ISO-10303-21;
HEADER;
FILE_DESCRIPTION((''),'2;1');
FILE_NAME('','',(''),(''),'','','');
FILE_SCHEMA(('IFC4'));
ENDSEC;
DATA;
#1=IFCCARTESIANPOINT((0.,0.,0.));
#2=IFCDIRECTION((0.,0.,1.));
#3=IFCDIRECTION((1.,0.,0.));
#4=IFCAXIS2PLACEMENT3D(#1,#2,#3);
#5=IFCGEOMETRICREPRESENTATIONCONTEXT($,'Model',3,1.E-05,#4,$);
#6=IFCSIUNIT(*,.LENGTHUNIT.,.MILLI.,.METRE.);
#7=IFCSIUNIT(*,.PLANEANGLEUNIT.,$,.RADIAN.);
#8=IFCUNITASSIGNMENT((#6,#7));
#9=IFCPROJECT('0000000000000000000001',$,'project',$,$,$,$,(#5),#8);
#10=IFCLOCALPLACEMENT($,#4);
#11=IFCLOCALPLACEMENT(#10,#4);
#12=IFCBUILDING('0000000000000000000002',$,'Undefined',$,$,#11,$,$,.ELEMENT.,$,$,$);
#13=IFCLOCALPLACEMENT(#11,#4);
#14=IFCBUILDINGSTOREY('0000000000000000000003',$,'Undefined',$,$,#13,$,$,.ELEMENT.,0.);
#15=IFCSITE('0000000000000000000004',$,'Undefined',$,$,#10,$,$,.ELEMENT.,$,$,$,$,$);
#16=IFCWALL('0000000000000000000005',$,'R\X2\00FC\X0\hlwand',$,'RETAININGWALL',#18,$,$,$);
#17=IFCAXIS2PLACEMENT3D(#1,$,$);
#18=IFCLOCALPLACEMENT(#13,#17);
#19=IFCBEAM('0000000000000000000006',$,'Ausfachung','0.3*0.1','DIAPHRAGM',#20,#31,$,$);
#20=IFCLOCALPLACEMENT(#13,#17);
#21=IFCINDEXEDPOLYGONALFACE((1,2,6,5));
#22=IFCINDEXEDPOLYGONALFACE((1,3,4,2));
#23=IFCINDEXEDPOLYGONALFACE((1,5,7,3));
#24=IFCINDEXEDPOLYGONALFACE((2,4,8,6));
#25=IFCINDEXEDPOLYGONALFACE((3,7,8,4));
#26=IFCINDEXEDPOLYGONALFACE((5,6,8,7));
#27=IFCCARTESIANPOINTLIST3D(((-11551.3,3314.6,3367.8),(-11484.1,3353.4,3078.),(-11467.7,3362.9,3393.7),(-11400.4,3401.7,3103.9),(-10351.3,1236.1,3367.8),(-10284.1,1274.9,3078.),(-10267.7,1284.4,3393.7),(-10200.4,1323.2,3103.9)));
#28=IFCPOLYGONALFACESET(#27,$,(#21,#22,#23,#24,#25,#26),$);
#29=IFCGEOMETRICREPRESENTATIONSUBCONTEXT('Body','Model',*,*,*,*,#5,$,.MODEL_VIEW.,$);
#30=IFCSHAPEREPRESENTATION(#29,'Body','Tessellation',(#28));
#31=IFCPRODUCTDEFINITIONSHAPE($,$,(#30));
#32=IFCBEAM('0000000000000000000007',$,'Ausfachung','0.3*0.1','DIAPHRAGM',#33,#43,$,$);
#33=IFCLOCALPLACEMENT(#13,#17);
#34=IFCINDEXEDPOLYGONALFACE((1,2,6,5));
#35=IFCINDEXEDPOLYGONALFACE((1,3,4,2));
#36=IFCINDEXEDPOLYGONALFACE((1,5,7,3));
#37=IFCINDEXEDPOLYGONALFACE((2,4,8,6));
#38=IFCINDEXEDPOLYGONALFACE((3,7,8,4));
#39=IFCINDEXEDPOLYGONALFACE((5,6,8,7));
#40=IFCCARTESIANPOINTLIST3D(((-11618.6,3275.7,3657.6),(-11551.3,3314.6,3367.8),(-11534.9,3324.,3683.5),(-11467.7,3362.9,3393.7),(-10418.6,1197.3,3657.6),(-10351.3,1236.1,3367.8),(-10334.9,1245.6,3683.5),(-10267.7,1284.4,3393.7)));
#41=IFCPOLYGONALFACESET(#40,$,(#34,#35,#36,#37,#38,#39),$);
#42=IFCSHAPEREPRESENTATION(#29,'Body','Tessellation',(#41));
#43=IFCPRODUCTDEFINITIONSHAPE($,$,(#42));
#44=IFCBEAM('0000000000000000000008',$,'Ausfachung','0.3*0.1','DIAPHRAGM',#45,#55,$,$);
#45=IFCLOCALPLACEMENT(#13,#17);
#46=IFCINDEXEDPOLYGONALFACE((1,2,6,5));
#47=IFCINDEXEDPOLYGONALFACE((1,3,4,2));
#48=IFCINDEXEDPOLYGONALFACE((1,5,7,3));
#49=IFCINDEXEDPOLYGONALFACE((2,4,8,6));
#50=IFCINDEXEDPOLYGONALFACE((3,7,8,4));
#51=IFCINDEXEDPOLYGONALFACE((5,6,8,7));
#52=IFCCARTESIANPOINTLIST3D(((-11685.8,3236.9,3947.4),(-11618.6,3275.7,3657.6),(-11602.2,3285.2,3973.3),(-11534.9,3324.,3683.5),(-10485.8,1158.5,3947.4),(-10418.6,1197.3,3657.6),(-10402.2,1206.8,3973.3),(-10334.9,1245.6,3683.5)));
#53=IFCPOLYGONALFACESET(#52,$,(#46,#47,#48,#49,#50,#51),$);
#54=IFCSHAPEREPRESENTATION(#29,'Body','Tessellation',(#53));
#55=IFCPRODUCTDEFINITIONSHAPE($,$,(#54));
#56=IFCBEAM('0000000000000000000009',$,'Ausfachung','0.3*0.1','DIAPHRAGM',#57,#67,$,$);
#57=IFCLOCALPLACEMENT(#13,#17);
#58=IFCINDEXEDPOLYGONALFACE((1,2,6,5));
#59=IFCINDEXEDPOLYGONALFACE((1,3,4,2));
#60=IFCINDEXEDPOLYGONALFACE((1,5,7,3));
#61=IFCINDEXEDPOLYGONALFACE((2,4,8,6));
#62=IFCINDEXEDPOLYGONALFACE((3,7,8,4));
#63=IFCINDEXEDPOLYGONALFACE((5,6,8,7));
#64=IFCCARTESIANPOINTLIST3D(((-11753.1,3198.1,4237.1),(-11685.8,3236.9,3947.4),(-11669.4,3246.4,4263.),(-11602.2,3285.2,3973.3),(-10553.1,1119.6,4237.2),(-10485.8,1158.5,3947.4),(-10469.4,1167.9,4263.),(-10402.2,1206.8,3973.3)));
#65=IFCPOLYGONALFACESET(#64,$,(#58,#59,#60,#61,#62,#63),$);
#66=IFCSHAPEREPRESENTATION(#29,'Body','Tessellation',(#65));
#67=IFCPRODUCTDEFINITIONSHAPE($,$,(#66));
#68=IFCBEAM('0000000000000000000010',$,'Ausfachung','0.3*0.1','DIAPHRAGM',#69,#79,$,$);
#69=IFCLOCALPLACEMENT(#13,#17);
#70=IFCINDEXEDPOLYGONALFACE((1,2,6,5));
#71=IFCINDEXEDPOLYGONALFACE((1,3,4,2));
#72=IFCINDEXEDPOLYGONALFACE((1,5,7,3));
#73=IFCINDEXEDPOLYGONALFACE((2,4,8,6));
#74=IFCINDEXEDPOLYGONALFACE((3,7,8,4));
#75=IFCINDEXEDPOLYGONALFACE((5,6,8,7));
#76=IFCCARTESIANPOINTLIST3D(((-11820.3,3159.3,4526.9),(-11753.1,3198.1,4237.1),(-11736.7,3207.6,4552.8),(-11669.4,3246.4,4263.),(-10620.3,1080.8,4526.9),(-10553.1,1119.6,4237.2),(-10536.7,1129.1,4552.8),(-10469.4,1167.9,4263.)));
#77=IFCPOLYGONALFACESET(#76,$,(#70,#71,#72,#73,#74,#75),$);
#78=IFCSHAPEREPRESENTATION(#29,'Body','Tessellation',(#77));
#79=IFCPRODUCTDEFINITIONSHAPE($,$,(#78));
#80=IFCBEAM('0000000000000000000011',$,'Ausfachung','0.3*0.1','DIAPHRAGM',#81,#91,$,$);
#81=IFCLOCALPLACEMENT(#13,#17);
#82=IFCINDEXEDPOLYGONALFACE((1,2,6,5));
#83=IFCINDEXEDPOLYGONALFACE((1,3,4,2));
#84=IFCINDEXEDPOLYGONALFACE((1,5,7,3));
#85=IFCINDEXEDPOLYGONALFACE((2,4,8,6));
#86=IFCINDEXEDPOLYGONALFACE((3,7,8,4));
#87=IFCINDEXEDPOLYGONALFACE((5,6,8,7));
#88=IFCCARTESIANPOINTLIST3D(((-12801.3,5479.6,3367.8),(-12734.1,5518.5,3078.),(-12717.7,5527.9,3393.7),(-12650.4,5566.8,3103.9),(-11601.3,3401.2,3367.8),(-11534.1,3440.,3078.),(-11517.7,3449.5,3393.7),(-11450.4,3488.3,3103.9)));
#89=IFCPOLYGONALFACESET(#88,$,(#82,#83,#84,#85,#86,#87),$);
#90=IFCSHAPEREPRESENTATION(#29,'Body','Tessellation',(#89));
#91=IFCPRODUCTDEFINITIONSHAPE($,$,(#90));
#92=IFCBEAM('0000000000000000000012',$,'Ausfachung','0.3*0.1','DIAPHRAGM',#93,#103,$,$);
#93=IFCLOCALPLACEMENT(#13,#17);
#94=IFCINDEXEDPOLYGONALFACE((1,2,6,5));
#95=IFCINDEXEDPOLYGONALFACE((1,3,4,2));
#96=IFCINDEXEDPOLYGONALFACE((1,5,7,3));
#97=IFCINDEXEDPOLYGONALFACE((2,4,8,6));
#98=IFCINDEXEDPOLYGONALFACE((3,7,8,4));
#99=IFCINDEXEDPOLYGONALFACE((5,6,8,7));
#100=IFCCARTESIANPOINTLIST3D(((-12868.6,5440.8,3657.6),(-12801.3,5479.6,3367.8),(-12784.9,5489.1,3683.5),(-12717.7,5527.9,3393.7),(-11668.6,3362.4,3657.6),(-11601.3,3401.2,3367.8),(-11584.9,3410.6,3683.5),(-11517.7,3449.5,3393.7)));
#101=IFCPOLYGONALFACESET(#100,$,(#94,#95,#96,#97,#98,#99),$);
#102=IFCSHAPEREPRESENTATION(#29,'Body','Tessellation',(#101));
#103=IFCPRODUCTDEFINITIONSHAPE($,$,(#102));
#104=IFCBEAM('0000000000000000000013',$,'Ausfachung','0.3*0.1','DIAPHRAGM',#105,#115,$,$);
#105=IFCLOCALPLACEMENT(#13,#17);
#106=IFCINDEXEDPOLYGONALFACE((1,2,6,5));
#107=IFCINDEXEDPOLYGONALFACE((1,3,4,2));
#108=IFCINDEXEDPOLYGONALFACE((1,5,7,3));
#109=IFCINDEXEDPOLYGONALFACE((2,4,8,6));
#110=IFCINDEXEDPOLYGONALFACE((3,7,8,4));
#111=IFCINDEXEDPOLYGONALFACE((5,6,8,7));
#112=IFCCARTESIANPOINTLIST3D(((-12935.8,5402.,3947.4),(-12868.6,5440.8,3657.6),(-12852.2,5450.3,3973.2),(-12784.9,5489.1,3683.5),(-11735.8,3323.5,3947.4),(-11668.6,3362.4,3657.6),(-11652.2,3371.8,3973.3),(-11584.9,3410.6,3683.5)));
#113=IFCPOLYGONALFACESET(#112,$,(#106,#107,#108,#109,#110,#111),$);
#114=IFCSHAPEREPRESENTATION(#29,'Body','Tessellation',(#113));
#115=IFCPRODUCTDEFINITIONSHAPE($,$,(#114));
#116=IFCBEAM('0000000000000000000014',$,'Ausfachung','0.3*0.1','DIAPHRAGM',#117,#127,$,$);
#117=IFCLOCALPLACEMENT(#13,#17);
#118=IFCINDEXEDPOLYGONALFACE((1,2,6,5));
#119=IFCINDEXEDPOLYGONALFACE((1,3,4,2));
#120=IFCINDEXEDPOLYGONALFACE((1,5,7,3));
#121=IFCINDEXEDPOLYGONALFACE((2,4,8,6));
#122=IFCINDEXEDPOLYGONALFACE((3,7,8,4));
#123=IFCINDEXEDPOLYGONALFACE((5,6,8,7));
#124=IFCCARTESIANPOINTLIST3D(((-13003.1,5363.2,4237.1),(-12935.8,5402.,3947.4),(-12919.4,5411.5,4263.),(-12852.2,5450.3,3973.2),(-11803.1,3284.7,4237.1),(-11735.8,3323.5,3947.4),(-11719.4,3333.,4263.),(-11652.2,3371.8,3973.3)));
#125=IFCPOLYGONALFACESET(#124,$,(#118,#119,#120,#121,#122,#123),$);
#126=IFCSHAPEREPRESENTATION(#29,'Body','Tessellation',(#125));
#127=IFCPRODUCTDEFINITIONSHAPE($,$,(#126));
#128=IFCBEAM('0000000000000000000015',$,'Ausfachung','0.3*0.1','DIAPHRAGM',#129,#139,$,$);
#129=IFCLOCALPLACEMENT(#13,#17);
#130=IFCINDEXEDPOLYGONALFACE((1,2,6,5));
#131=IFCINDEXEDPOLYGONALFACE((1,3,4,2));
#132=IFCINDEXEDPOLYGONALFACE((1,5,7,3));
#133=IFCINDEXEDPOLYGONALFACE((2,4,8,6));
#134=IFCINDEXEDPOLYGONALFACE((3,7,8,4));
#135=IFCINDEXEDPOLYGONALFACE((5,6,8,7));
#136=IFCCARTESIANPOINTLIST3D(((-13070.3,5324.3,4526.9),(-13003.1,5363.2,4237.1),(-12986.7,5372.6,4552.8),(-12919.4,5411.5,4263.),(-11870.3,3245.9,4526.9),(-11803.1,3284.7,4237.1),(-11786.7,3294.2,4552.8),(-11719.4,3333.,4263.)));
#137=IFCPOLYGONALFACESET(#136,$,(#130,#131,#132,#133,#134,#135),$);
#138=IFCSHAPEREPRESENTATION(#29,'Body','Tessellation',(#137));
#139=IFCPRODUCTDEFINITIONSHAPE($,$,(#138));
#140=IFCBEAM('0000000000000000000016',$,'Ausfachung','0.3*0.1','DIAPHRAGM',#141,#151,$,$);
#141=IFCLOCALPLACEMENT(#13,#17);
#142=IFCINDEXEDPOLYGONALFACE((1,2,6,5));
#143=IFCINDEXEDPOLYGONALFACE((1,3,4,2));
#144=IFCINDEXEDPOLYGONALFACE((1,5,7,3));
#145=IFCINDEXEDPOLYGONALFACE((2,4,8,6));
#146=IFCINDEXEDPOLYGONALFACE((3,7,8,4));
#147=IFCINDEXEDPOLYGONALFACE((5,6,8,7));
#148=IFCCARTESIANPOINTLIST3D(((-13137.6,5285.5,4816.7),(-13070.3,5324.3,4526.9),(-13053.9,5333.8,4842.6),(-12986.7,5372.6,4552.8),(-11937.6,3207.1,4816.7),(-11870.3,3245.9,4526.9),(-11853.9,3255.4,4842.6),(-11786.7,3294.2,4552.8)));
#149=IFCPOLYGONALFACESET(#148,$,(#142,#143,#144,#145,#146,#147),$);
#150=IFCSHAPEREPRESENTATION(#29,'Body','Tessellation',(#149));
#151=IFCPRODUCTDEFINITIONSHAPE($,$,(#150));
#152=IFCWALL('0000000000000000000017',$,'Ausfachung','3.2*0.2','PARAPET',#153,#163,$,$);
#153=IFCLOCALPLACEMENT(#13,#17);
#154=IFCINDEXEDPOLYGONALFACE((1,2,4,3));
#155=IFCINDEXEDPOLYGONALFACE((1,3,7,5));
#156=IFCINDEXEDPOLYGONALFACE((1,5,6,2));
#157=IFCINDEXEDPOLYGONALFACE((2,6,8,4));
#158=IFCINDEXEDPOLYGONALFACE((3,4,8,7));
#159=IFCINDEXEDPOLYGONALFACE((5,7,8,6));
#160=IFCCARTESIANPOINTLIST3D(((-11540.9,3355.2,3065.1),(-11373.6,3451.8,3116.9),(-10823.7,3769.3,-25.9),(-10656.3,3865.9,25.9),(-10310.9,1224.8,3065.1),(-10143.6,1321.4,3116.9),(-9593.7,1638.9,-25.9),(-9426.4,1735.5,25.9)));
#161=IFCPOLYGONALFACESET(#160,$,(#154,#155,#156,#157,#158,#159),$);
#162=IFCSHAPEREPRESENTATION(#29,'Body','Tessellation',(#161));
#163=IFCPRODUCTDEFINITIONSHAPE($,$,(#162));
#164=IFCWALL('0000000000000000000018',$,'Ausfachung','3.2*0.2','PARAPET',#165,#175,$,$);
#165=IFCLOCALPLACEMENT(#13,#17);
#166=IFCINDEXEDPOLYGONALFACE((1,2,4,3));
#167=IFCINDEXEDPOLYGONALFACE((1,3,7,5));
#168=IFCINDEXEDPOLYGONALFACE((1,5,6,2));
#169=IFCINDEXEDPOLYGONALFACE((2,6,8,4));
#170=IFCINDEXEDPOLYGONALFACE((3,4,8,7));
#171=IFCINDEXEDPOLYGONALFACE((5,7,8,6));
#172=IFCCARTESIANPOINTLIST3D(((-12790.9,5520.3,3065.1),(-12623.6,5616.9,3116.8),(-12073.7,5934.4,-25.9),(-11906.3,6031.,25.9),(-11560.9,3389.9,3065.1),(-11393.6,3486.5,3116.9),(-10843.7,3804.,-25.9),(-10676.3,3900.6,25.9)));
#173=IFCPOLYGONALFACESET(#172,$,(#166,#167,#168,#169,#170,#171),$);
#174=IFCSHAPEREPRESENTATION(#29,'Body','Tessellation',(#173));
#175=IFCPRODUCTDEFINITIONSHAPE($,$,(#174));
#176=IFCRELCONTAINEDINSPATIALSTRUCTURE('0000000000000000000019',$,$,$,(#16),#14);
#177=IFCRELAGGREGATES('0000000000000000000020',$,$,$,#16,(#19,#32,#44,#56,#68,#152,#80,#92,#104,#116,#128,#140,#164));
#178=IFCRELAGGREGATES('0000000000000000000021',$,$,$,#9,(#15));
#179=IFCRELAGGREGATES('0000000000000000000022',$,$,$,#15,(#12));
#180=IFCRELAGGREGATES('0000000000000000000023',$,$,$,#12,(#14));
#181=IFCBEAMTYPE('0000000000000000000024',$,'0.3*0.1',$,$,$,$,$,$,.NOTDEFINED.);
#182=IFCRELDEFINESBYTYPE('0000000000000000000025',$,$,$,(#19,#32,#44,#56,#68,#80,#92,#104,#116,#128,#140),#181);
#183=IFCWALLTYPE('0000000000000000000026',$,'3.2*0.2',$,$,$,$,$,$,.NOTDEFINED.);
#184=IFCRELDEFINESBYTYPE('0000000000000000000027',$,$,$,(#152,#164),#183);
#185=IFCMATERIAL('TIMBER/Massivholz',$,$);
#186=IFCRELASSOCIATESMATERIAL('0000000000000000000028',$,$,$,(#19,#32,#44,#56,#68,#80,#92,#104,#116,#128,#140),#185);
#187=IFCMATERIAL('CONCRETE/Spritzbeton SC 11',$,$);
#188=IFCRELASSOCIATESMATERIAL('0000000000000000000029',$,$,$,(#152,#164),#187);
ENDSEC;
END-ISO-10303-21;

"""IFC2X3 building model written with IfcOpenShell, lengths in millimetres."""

from ifc_helpers import new_model, si_unit, frame, frame_2d, origin_with_axes, origin_2d_with_axis, place, context, subcontext, project, spatial, rectangle, extrude, material, type_object, element, aggregate, save


model = new_model("IFC2X3")

# Units and contexts
model_context = context("Model", 3, precision=1e-05, world=origin_with_axes())
body_context = subcontext(model_context, "Body", "Model", "MODEL_VIEW")
ifc_project = project(units=[si_unit("LENGTHUNIT", "METRE", prefix="MILLI"), si_unit("PLANEANGLEUNIT", "RADIAN")], contexts=[model_context])

# Site, building, storey
site_placement = place(None, origin_with_axes())
site = spatial("IfcSite", under=ifc_project, at=site_placement, Name="Undefined", CompositionType="ELEMENT")
building_placement = place(site_placement, origin_with_axes())
building = spatial("IfcBuilding", under=site, at=building_placement, Name="Undefined", CompositionType="ELEMENT")
storey_placement = place(building_placement, origin_with_axes())
storey = spatial("IfcBuildingStorey", under=building, at=storey_placement, Name="Undefined", CompositionType="ELEMENT", Elevation=0.0)

# Wall
wall_1_placement = place(storey_placement, origin_with_axes())
wall_1 = element("IfcWall", 1, at=wall_1_placement, inside=storey, Name="Rühlwand", ObjectType="RETAININGWALL")

# Beams
ifc_material_1 = material(Name="TIMBER/Massivholz")
beam_type_1 = type_object("IfcBeamType", Name="0.3*0.1", PredefinedType="NOTDEFINED")
beam_1_placement = place(wall_1_placement, frame((-11475.9, 3358.1, 3235.9), z_axis=(0.224147, 0.129405, -0.965926), x_axis=(0.499999, -0.866026, 0.000005)))
beam_1 = element("IfcBeam", 2, at=beam_1_placement, type_object=beam_type_1, material=ifc_material_1, Name="Ausfachung", Description="0.3*0.1", ObjectType="DIAPHRAGM", context=body_context, shape_type="SweptSolid", body=[
    extrude(rectangle(XDim=100.0, YDim=300.0, at=origin_2d_with_axis()), frame((2400.0, 0.0, 0.0), z_axis=(-1.0, 0.0, 0.0), x_axis=(0.0, -1.0, 0.0)), (0.0, 0.0, 1.0), 2400.0),
])
beam_2_placement = place(wall_1_placement, frame((-11543.1, 3319.3, 3525.6), z_axis=(0.224147, 0.129405, -0.965926), x_axis=(0.499999, -0.866026, 0.000005)))
beam_2 = element("IfcBeam", 3, at=beam_2_placement, type_object=beam_type_1, material=ifc_material_1, Name="Ausfachung", Description="0.3*0.1", ObjectType="DIAPHRAGM", context=body_context, shape_type="SweptSolid", body=[
    extrude(rectangle(XDim=100.0, YDim=300.0, at=origin_2d_with_axis()), frame((2400.0, 0.0, 0.0), z_axis=(-1.0, 0.0, 0.0), x_axis=(0.0, -1.0, 0.0)), (0.0, 0.0, 1.0), 2400.0),
])
beam_3_placement = place(wall_1_placement, frame((-11610.4, 3280.5, 3815.4), z_axis=(0.224147, 0.129405, -0.965926), x_axis=(0.499999, -0.866026, 0.000005)))
beam_3 = element("IfcBeam", 4, at=beam_3_placement, type_object=beam_type_1, material=ifc_material_1, Name="Ausfachung", Description="0.3*0.1", ObjectType="DIAPHRAGM", context=body_context, shape_type="SweptSolid", body=[
    extrude(rectangle(XDim=100.0, YDim=300.0, at=origin_2d_with_axis()), frame((2400.0, 0.0, 0.0), z_axis=(-1.0, 0.0, 0.0), x_axis=(0.0, -1.0, 0.0)), (0.0, 0.0, 1.0), 2400.0),
])
beam_4_placement = place(wall_1_placement, frame((-11677.6, 3241.7, 4105.2), z_axis=(0.224147, 0.129405, -0.965926), x_axis=(0.499999, -0.866026, 0.000005)))
beam_4 = element("IfcBeam", 5, at=beam_4_placement, type_object=beam_type_1, material=ifc_material_1, Name="Ausfachung", Description="0.3*0.1", ObjectType="DIAPHRAGM", context=body_context, shape_type="SweptSolid", body=[
    extrude(rectangle(XDim=100.0, YDim=300.0, at=origin_2d_with_axis()), frame((2400.0, 0.0, 0.0), z_axis=(-1.0, 0.0, 0.0), x_axis=(0.0, -1.0, 0.0)), (0.0, 0.0, 1.0), 2400.0),
])
beam_5_placement = place(wall_1_placement, frame((-11744.9, 3202.8, 4395.0), z_axis=(0.224147, 0.129405, -0.965926), x_axis=(0.499999, -0.866026, 0.000005)))
beam_5 = element("IfcBeam", 6, at=beam_5_placement, type_object=beam_type_1, material=ifc_material_1, Name="Ausfachung", Description="0.3*0.1", ObjectType="DIAPHRAGM", context=body_context, shape_type="SweptSolid", body=[
    extrude(rectangle(XDim=100.0, YDim=300.0, at=origin_2d_with_axis()), frame((2400.0, 0.0, 0.0), z_axis=(-1.0, 0.0, 0.0), x_axis=(0.0, -1.0, 0.0)), (0.0, 0.0, 1.0), 2400.0),
])
beam_6_placement = place(wall_1_placement, frame((-12725.9, 5523.2, 3235.9), z_axis=(0.224147, 0.129405, -0.965926), x_axis=(0.499999, -0.866026, 0.000005)))
beam_6 = element("IfcBeam", 7, at=beam_6_placement, type_object=beam_type_1, material=ifc_material_1, Name="Ausfachung", Description="0.3*0.1", ObjectType="DIAPHRAGM", context=body_context, shape_type="SweptSolid", body=[
    extrude(rectangle(XDim=100.0, YDim=300.0, at=origin_2d_with_axis()), frame((2400.0, 0.0, 0.0), z_axis=(-1.0, 0.0, 0.0), x_axis=(0.0, -1.0, 0.0)), (0.0, 0.0, 1.0), 2400.0),
])
beam_7_placement = place(wall_1_placement, frame((-12793.1, 5484.4, 3525.6), z_axis=(0.224147, 0.129405, -0.965926), x_axis=(0.499999, -0.866026, 0.000005)))
beam_7 = element("IfcBeam", 8, at=beam_7_placement, type_object=beam_type_1, material=ifc_material_1, Name="Ausfachung", Description="0.3*0.1", ObjectType="DIAPHRAGM", context=body_context, shape_type="SweptSolid", body=[
    extrude(rectangle(XDim=100.0, YDim=300.0, at=origin_2d_with_axis()), frame((2400.0, 0.0, 0.0), z_axis=(-1.0, 0.0, 0.0), x_axis=(0.0, -1.0, 0.0)), (0.0, 0.0, 1.0), 2400.0),
])
beam_8_placement = place(wall_1_placement, frame((-12860.4, 5445.5, 3815.4), z_axis=(0.224147, 0.129405, -0.965926), x_axis=(0.499999, -0.866026, 0.000005)))
beam_8 = element("IfcBeam", 9, at=beam_8_placement, type_object=beam_type_1, material=ifc_material_1, Name="Ausfachung", Description="0.3*0.1", ObjectType="DIAPHRAGM", context=body_context, shape_type="SweptSolid", body=[
    extrude(rectangle(XDim=100.0, YDim=300.0, at=origin_2d_with_axis()), frame((2400.0, 0.0, 0.0), z_axis=(-1.0, 0.0, 0.0), x_axis=(0.0, -1.0, 0.0)), (0.0, 0.0, 1.0), 2400.0),
])
beam_9_placement = place(wall_1_placement, frame((-12927.6, 5406.7, 4105.2), z_axis=(0.224147, 0.129405, -0.965926), x_axis=(0.499999, -0.866026, 0.000005)))
beam_9 = element("IfcBeam", 10, at=beam_9_placement, type_object=beam_type_1, material=ifc_material_1, Name="Ausfachung", Description="0.3*0.1", ObjectType="DIAPHRAGM", context=body_context, shape_type="SweptSolid", body=[
    extrude(rectangle(XDim=100.0, YDim=300.0, at=origin_2d_with_axis()), frame((2400.0, 0.0, 0.0), z_axis=(-1.0, 0.0, 0.0), x_axis=(0.0, -1.0, 0.0)), (0.0, 0.0, 1.0), 2400.0),
])
beam_10_placement = place(wall_1_placement, frame((-12994.9, 5367.9, 4395.0), z_axis=(0.224147, 0.129405, -0.965926), x_axis=(0.499999, -0.866026, 0.000005)))
beam_10 = element("IfcBeam", 11, at=beam_10_placement, type_object=beam_type_1, material=ifc_material_1, Name="Ausfachung", Description="0.3*0.1", ObjectType="DIAPHRAGM", context=body_context, shape_type="SweptSolid", body=[
    extrude(rectangle(XDim=100.0, YDim=300.0, at=origin_2d_with_axis()), frame((2400.0, 0.0, 0.0), z_axis=(-1.0, 0.0, 0.0), x_axis=(0.0, -1.0, 0.0)), (0.0, 0.0, 1.0), 2400.0),
])
beam_11_placement = place(wall_1_placement, frame((-13062.1, 5329.1, 4684.7), z_axis=(0.224147, 0.129405, -0.965926), x_axis=(0.499999, -0.866026, 0.000005)))
beam_11 = element("IfcBeam", 12, at=beam_11_placement, type_object=beam_type_1, material=ifc_material_1, Name="Ausfachung", Description="0.3*0.1", ObjectType="DIAPHRAGM", context=body_context, shape_type="SweptSolid", body=[
    extrude(rectangle(XDim=100.0, YDim=300.0, at=origin_2d_with_axis()), frame((2400.0, 0.0, 0.0), z_axis=(-1.0, 0.0, 0.0), x_axis=(0.0, -1.0, 0.0)), (0.0, 0.0, 1.0), 2400.0),
])

# Walls
ifc_material_2 = material(Name="CONCRETE/Spritzbeton SC 11")
wall_type = type_object("IfcWallType", Name="3.2*0.2", PredefinedType="NOTDEFINED")
wall_2_placement = place(wall_1_placement, frame((-10740.0, 3817.6, 0.0), z_axis=(-0.224147, -0.129405, 0.965926), x_axis=(0.499999, -0.866026, 0.000005)))
wall_2 = element("IfcWall", 13, at=wall_2_placement, type_object=wall_type, material=ifc_material_2, Name="Ausfachung", Description="3.2*0.2", ObjectType="PARAPET", context=body_context, shape_type="SweptSolid", body=[
    extrude(rectangle(XDim=2460.0, YDim=200.0, at=frame_2d((0.0, 1230.0), x_axis=(0.0, -1.0))), frame((0.0, 0.0, 0.0), z_axis=(0.0, 0.0, 1.0), x_axis=(0.0, -1.0, 0.0)), (0.0, 0.0, 1.0), 3200.0),
])
wall_3_placement = place(wall_1_placement, frame((-11990.0, 5982.7, 0.0), z_axis=(-0.224147, -0.129405, 0.965926), x_axis=(0.499999, -0.866026, 0.000005)))
wall_3 = element("IfcWall", 14, at=wall_3_placement, type_object=wall_type, material=ifc_material_2, Name="Ausfachung", Description="3.2*0.2", ObjectType="PARAPET", context=body_context, shape_type="SweptSolid", body=[
    extrude(rectangle(XDim=2460.0, YDim=200.0, at=frame_2d((0.0, 1230.0), x_axis=(0.0, -1.0))), frame((0.0, 0.0, 0.0), z_axis=(0.0, 0.0, 1.0), x_axis=(0.0, -1.0, 0.0)), (0.0, 0.0, 1.0), 3200.0),
])

aggregate(wall_1, [beam_1, beam_2, beam_3, beam_4, beam_5, wall_2, beam_6, beam_7, beam_8, beam_9, beam_10, beam_11, wall_3])

save(model, "model.ifc")
